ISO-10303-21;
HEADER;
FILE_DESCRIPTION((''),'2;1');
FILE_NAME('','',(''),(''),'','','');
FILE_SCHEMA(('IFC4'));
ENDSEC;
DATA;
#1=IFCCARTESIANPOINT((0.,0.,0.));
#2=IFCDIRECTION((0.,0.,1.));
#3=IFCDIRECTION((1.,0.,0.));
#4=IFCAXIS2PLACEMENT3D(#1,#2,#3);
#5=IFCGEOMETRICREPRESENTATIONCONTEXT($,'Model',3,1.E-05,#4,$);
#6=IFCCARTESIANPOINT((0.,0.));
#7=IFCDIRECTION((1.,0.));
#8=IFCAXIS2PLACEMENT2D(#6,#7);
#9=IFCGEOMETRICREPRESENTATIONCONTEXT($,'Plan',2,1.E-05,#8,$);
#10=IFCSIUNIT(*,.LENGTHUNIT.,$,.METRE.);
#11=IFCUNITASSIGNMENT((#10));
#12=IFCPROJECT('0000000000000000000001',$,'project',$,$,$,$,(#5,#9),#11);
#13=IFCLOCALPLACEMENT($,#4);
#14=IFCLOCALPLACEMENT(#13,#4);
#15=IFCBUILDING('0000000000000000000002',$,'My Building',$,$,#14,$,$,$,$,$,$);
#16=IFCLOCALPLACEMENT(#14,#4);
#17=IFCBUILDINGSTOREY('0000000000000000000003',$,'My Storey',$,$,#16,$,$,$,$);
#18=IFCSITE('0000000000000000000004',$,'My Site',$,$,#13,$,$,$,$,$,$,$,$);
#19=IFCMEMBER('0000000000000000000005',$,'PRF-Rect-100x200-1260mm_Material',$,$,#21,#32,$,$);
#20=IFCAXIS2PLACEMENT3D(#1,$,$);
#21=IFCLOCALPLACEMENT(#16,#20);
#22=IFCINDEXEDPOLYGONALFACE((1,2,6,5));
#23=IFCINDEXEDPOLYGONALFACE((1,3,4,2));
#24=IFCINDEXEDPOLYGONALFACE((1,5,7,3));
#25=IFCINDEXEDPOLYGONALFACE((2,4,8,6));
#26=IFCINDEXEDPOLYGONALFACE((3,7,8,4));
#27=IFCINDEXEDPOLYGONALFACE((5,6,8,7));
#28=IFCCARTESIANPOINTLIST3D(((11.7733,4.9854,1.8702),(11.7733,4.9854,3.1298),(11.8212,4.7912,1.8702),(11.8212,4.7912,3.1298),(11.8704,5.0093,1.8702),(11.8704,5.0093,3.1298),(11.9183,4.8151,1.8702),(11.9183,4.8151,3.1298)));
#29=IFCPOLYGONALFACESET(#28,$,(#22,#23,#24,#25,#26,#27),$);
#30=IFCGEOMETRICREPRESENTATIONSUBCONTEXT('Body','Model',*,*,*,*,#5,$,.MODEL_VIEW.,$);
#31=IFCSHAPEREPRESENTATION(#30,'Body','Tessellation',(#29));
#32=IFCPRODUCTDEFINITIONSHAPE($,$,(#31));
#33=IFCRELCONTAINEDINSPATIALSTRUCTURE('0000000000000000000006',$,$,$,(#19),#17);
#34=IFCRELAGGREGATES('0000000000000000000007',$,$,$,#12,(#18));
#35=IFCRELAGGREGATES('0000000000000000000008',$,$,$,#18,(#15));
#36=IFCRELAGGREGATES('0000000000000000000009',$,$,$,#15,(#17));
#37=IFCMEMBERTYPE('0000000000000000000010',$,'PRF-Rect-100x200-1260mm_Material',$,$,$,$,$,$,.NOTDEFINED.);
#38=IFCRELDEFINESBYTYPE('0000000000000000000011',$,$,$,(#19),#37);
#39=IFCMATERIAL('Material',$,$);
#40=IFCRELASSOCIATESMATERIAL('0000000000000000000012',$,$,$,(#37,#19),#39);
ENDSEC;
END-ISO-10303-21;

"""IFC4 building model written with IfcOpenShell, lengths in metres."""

from ifc_helpers import new_model, si_unit, frame, origin, origin_with_axes, origin_2d_with_axis, place, context, subcontext, project, spatial, rectangle, extrude, material, material_profile, profile_set, profile_usage, type_object, element, save


model = new_model("IFC4")

# Units and contexts
model_context = context("Model", 3, precision=1e-05, world=origin_with_axes())
plan_context = context("Plan", 2, precision=1e-05, world=origin_2d_with_axis())
body_context = subcontext(model_context, "Body", "Model", "MODEL_VIEW")
ifc_project = project(units=[si_unit("LENGTHUNIT", "METRE")], contexts=[model_context, plan_context])

# Site, building, storey
site_placement = place(None, origin_with_axes())
site = spatial("IfcSite", under=ifc_project, at=site_placement, Name="My Site")
building_placement = place(site_placement, origin_with_axes())
building = spatial("IfcBuilding", under=site, at=building_placement, Name="My Building")
storey_placement = place(building_placement, origin_with_axes())
storey = spatial("IfcBuildingStorey", under=building, at=storey_placement, Name="My Storey")

# Member
ifc_material = material(Name="Material")
ifc_material_profile_1 = material_profile(ifc_material, rectangle(XDim=0.1, YDim=0.2))
ifc_profile_set_1 = profile_set([ifc_material_profile_1], Name="PRF-Rect-100x200-1260mm_Material")
member_type_1 = type_object("IfcMemberType", Name="PRF-Rect-100x200-1260mm_Material", PredefinedType="NOTDEFINED", material=ifc_profile_set_1)
ifc_profile_usage_1 = profile_usage(ifc_profile_set_1, cardinal=5)
member_1_placement = place(storey_placement, frame((11.8458, 4.9002, 3.1298), z_axis=(0.0, 0.0, -1.0), x_axis=(-0.970857, -0.239658, 0.0)))
element("IfcMember", 1, at=member_1_placement, inside=storey, type_object=member_type_1, material=ifc_profile_usage_1, Name="PRF-Rect-100x200-1260mm_Material", context=body_context, shape_type="SweptSolid", body=[
    extrude(rectangle(XDim=0.1, YDim=0.2), origin(), (0.0, 0.0, 1.0), 1.2597),
])

save(model, "model.ifc")
